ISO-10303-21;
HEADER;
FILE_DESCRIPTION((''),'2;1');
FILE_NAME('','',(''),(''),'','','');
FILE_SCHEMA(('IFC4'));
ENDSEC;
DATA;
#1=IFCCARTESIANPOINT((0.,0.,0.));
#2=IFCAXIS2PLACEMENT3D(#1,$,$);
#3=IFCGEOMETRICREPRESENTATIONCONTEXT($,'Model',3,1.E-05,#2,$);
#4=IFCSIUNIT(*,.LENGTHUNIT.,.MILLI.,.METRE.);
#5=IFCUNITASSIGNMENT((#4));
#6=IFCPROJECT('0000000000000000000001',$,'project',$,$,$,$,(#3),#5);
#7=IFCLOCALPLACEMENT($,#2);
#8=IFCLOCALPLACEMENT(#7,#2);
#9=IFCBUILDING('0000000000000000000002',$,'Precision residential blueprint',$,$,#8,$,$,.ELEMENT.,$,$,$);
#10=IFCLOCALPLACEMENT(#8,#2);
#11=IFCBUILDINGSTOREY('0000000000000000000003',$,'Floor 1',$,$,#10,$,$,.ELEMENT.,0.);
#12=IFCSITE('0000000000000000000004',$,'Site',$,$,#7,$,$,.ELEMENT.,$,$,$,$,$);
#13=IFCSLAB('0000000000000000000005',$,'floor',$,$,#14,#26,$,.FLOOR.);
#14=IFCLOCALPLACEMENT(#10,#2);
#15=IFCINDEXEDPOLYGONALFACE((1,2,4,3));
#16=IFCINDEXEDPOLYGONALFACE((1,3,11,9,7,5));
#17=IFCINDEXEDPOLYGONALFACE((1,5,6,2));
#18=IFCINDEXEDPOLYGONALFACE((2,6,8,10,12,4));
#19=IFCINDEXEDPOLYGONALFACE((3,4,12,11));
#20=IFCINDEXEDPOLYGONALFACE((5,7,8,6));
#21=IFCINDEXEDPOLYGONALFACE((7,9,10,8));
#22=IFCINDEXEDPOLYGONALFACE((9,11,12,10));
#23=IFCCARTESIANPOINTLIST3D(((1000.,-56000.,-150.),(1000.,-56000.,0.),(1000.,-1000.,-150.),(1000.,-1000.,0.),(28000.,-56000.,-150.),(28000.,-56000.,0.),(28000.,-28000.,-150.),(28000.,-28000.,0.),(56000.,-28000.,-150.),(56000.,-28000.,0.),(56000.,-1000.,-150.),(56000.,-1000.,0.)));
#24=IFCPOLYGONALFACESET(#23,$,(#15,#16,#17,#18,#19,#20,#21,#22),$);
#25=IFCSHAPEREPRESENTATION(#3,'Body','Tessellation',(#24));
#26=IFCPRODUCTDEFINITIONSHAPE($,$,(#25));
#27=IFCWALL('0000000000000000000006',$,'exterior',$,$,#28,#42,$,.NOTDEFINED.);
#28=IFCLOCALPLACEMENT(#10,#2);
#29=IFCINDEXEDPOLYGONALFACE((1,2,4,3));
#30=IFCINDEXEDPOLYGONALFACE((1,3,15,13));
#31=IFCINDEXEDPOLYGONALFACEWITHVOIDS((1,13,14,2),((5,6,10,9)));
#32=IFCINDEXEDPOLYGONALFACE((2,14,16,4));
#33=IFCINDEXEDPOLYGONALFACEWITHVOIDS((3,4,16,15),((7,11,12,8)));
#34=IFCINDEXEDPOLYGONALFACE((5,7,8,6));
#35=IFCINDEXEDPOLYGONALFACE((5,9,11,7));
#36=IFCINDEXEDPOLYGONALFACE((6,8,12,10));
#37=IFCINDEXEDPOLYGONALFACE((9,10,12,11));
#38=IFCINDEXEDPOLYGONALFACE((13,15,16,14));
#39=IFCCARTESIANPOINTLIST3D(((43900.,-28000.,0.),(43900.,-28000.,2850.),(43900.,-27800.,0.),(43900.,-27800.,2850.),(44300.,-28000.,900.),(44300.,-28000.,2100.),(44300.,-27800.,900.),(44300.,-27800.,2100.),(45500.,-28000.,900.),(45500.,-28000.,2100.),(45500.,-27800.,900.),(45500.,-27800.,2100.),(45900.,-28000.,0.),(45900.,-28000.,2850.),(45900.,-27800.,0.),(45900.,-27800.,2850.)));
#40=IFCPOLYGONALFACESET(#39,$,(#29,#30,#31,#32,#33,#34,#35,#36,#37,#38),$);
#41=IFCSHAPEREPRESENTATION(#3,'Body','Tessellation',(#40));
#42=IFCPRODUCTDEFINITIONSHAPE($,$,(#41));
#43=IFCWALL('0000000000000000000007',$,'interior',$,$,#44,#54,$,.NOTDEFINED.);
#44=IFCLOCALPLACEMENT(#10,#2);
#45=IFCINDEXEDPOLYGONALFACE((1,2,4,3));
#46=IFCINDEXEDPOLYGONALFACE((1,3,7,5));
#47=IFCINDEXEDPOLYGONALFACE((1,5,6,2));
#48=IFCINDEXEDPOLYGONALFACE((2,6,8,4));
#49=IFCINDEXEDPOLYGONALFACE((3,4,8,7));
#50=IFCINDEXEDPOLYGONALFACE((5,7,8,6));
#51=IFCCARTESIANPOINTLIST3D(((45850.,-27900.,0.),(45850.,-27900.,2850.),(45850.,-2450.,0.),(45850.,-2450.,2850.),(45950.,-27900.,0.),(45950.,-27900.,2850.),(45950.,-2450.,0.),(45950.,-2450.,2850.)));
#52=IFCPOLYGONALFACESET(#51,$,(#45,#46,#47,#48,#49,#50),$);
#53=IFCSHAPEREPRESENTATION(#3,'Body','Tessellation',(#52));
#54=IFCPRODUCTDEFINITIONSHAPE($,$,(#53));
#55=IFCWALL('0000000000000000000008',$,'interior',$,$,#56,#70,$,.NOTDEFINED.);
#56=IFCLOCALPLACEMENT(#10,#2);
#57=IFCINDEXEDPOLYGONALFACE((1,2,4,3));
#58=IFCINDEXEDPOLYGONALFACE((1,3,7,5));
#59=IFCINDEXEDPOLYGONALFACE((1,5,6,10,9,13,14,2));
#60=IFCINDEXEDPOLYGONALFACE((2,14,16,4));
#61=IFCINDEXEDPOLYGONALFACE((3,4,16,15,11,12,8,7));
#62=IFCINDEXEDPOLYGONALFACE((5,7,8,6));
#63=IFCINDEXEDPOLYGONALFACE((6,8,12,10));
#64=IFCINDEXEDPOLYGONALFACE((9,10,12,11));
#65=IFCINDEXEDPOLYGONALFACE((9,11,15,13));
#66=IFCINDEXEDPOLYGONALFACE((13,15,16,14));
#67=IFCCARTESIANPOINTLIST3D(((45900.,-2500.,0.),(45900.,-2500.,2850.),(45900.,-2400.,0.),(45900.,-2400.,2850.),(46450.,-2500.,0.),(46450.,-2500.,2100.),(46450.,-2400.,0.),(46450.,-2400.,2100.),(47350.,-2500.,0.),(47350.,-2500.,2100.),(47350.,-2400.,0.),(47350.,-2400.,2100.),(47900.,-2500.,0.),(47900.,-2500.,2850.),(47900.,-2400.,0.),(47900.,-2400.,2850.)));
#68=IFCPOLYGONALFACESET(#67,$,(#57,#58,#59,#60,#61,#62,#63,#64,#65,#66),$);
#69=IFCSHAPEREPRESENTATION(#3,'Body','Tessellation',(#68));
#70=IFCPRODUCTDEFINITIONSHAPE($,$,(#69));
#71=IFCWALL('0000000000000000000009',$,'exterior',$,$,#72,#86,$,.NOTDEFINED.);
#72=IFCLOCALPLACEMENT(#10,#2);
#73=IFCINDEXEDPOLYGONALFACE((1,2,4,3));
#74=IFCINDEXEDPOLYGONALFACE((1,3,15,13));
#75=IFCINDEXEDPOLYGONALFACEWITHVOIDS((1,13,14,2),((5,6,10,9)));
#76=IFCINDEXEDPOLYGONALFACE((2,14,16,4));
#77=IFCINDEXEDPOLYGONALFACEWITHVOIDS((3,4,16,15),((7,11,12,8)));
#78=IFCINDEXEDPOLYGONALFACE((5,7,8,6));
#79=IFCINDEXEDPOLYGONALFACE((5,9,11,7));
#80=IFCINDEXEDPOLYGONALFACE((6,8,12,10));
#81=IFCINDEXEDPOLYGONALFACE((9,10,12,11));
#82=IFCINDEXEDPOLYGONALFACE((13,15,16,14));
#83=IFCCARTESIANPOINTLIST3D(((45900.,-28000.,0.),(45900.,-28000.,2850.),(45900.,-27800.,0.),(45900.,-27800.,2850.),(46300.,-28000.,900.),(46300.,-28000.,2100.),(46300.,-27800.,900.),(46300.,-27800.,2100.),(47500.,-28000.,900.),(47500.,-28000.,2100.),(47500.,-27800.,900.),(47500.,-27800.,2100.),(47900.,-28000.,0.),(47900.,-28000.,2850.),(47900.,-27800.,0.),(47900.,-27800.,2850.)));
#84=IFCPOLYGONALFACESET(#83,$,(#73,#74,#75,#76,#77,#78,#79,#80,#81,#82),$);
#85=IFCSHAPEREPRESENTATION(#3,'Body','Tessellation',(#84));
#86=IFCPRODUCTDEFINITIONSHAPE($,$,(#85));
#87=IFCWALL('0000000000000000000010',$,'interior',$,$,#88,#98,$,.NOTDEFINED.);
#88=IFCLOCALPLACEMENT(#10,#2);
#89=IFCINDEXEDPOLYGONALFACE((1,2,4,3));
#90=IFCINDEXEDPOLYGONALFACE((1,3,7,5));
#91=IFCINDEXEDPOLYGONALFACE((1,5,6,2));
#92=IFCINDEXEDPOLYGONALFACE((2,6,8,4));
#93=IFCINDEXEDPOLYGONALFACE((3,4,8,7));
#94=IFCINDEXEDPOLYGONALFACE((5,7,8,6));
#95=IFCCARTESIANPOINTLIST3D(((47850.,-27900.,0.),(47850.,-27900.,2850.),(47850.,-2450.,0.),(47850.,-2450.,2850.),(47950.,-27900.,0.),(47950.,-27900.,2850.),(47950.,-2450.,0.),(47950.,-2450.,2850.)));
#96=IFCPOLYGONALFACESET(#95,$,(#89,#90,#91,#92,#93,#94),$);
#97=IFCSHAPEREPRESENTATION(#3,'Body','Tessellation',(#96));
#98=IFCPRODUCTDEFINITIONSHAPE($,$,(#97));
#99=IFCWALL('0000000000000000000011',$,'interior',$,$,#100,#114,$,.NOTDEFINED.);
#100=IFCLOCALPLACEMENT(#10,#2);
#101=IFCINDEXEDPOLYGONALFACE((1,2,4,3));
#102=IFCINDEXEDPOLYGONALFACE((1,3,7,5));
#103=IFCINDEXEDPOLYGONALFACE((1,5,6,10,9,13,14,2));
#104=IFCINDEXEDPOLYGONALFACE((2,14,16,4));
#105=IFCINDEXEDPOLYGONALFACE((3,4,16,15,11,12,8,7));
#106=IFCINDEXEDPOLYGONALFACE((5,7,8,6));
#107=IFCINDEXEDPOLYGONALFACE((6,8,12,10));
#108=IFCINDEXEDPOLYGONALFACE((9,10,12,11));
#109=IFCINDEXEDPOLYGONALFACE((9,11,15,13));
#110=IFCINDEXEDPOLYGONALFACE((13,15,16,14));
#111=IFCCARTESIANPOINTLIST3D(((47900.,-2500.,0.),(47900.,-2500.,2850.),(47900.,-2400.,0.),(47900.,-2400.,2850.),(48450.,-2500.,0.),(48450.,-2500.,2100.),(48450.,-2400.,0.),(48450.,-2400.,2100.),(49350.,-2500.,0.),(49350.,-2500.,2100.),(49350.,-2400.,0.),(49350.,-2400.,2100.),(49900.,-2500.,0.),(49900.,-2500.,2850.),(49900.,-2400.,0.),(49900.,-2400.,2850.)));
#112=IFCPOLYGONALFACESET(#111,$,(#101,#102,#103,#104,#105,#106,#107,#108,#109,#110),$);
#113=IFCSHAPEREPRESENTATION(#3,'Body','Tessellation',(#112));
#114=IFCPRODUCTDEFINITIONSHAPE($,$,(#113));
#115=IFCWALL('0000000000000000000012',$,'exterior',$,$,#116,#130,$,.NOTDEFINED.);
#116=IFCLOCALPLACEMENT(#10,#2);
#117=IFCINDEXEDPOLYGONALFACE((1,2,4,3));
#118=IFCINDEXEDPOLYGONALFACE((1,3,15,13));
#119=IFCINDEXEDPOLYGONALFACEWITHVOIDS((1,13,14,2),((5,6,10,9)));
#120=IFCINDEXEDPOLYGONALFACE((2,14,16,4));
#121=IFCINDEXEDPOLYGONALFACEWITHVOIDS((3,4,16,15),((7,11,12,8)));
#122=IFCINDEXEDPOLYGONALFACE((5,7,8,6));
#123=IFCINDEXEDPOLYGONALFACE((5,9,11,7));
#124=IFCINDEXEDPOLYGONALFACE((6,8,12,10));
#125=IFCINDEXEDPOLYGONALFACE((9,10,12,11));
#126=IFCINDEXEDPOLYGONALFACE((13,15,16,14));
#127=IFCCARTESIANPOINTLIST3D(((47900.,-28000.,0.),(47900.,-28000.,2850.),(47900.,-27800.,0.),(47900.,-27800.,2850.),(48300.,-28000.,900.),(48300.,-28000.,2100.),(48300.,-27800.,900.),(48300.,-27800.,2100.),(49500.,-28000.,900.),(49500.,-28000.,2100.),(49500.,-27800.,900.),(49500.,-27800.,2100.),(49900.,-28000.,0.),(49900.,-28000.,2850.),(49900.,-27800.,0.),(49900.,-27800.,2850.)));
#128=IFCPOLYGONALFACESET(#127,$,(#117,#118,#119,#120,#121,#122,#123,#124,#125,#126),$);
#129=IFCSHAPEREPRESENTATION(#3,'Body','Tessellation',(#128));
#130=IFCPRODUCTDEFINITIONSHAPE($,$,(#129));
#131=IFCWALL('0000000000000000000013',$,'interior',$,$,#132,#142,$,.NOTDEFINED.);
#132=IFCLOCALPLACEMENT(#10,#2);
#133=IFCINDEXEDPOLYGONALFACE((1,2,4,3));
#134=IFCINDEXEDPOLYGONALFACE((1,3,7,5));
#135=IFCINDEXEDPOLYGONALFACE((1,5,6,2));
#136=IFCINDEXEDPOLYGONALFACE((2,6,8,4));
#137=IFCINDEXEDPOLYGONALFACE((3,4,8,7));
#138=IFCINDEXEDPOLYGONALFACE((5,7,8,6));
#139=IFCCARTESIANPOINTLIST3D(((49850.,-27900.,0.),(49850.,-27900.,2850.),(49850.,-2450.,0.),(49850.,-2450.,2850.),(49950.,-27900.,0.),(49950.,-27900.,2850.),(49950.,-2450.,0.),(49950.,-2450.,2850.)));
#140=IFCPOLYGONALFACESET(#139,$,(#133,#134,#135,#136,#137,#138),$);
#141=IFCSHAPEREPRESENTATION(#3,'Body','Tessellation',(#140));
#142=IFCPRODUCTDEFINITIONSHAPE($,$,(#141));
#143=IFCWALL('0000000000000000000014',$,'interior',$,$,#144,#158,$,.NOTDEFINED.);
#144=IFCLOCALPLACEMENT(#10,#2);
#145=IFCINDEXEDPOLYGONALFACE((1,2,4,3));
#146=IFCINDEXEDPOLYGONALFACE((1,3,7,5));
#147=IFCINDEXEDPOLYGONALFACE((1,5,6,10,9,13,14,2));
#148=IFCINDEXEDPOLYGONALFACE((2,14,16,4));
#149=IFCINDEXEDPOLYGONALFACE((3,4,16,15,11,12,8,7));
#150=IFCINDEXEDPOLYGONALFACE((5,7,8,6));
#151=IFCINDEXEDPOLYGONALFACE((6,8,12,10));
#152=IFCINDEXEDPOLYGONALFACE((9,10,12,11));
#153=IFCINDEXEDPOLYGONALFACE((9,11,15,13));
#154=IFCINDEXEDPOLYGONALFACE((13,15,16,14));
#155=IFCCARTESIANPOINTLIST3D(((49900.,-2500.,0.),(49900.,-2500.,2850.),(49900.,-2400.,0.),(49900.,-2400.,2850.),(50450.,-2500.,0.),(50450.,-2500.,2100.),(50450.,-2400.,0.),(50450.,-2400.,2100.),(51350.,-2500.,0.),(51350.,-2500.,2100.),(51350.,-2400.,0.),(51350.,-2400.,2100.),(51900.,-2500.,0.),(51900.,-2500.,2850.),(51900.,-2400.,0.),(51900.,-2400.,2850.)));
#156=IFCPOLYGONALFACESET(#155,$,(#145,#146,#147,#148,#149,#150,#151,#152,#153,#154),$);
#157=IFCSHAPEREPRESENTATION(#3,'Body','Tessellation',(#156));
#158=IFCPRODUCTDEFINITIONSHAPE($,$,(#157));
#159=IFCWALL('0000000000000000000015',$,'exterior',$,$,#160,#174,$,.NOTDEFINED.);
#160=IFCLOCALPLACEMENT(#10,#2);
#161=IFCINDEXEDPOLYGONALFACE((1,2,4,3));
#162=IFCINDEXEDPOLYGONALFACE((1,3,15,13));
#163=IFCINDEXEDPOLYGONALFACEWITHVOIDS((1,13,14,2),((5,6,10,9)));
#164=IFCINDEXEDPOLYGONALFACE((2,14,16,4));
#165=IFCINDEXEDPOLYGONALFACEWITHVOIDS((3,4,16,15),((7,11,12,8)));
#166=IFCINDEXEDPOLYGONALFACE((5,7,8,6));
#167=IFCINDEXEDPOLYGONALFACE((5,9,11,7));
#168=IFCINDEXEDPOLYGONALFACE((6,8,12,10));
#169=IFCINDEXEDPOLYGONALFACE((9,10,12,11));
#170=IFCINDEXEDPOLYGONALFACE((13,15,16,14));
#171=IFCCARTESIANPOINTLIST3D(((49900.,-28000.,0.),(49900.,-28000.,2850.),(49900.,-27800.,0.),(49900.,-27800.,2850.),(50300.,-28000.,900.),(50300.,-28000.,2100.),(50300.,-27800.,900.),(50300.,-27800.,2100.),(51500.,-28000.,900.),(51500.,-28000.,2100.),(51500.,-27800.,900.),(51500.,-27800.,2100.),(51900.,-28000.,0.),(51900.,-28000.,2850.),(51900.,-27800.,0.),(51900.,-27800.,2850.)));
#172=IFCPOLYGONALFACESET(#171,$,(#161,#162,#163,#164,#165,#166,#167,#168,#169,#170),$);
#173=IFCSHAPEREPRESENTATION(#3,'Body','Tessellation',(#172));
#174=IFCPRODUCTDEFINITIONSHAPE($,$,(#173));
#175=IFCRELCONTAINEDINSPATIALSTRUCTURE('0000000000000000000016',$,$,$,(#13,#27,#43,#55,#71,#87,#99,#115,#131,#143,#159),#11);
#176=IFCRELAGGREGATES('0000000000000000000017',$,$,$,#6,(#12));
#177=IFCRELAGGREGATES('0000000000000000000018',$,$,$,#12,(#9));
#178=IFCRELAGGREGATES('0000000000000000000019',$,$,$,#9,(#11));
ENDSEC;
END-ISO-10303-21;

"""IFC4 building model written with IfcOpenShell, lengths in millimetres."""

from ifc_helpers import new_model, si_unit, frame, origin, place, context, project, spatial, polyline, outline, extrude, element, save


model = new_model("IFC4")

# Units and contexts
model_context = context("Model", 3, precision=1e-05, world=origin())
ifc_project = project(units=[si_unit("LENGTHUNIT", "METRE", prefix="MILLI")], contexts=[model_context])

# Site, building, storey
site_placement = place(None, origin())
site = spatial("IfcSite", under=ifc_project, at=site_placement, Name="Site", CompositionType="ELEMENT")
building_placement = place(site_placement, origin())
building = spatial("IfcBuilding", under=site, at=building_placement, Name="Precision residential blueprint", CompositionType="ELEMENT")
storey_placement = place(building_placement, origin())
storey = spatial("IfcBuildingStorey", under=building, at=storey_placement, Name="Floor 1", CompositionType="ELEMENT", Elevation=0.0)

# Slab
slab_placement = place(storey_placement, origin())
element("IfcSlab", 1, at=slab_placement, inside=storey, Name="floor", PredefinedType="FLOOR", context=model_context, shape_type="SweptSolid", body=[
    extrude(outline(polyline([(1000.0, -56000.0), (28000.0, -56000.0), (28000.0, -28000.0), (56000.0, -28000.0), (56000.0, -1000.0), (1000.0, -1000.0), (1000.0, -56000.0)])), frame((0.0, 0.0, -150.0)), (0.0, 0.0, 1.0), 150.0),
])

# Wall, opening
wall_1_placement = place(storey_placement, origin())
wall_1 = element("IfcWall", 2, at=wall_1_placement, inside=storey, Name="exterior", PredefinedType="NOTDEFINED", context=model_context, shape_type="SweptSolid", body=[
    extrude(outline(polyline([(43900.0, -27800.0), (45900.0, -27800.0), (45900.0, -28000.0), (43900.0, -28000.0), (43900.0, -27800.0)])), origin(), (0.0, 0.0, 1.0), 2850.0),
])
opening_1_placement = place(storey_placement, origin())
element("IfcOpeningElement", 3, at=opening_1_placement, cuts=wall_1, PredefinedType="OPENING", context=model_context, shape_type="SweptSolid", body=[
    extrude(outline(polyline([(44300.0, -27800.0), (45500.0, -27800.0), (45500.0, -28000.0), (44300.0, -28000.0), (44300.0, -27800.0)])), frame((0.0, 0.0, 900.0)), (0.0, 0.0, 1.0), 1200.0),
])

# Wall
wall_2_placement = place(storey_placement, origin())
element("IfcWall", 4, at=wall_2_placement, inside=storey, Name="interior", PredefinedType="NOTDEFINED", context=model_context, shape_type="SweptSolid", body=[
    extrude(outline(polyline([(45950.0, -2450.0), (45950.0, -27900.0), (45850.0, -27900.0), (45850.0, -2450.0), (45950.0, -2450.0)])), origin(), (0.0, 0.0, 1.0), 2850.0),
])

# Walls, openings
wall_3_placement = place(storey_placement, origin())
wall_3 = element("IfcWall", 5, at=wall_3_placement, inside=storey, Name="interior", PredefinedType="NOTDEFINED", context=model_context, shape_type="SweptSolid", body=[
    extrude(outline(polyline([(45900.0, -2400.0), (47900.0, -2400.0), (47900.0, -2500.0), (45900.0, -2500.0), (45900.0, -2400.0)])), origin(), (0.0, 0.0, 1.0), 2850.0),
])
opening_2_placement = place(storey_placement, origin())
element("IfcOpeningElement", 6, at=opening_2_placement, cuts=wall_3, PredefinedType="OPENING", context=model_context, shape_type="SweptSolid", body=[
    extrude(outline(polyline([(46450.0, -2400.0), (47350.0, -2400.0), (47350.0, -2500.0), (46450.0, -2500.0), (46450.0, -2400.0)])), origin(), (0.0, 0.0, 1.0), 2100.0),
])
wall_4_placement = place(storey_placement, origin())
wall_4 = element("IfcWall", 7, at=wall_4_placement, inside=storey, Name="exterior", PredefinedType="NOTDEFINED", context=model_context, shape_type="SweptSolid", body=[
    extrude(outline(polyline([(45900.0, -27800.0), (47900.0, -27800.0), (47900.0, -28000.0), (45900.0, -28000.0), (45900.0, -27800.0)])), origin(), (0.0, 0.0, 1.0), 2850.0),
])
opening_3_placement = place(storey_placement, origin())
element("IfcOpeningElement", 8, at=opening_3_placement, cuts=wall_4, PredefinedType="OPENING", context=model_context, shape_type="SweptSolid", body=[
    extrude(outline(polyline([(46300.0, -27800.0), (47500.0, -27800.0), (47500.0, -28000.0), (46300.0, -28000.0), (46300.0, -27800.0)])), frame((0.0, 0.0, 900.0)), (0.0, 0.0, 1.0), 1200.0),
])

# Wall
wall_5_placement = place(storey_placement, origin())
element("IfcWall", 9, at=wall_5_placement, inside=storey, Name="interior", PredefinedType="NOTDEFINED", context=model_context, shape_type="SweptSolid", body=[
    extrude(outline(polyline([(47950.0, -2450.0), (47950.0, -27900.0), (47850.0, -27900.0), (47850.0, -2450.0), (47950.0, -2450.0)])), origin(), (0.0, 0.0, 1.0), 2850.0),
])

# Walls, openings
wall_6_placement = place(storey_placement, origin())
wall_6 = element("IfcWall", 10, at=wall_6_placement, inside=storey, Name="interior", PredefinedType="NOTDEFINED", context=model_context, shape_type="SweptSolid", body=[
    extrude(outline(polyline([(47900.0, -2400.0), (49900.0, -2400.0), (49900.0, -2500.0), (47900.0, -2500.0), (47900.0, -2400.0)])), origin(), (0.0, 0.0, 1.0), 2850.0),
])
opening_4_placement = place(storey_placement, origin())
element("IfcOpeningElement", 11, at=opening_4_placement, cuts=wall_6, PredefinedType="OPENING", context=model_context, shape_type="SweptSolid", body=[
    extrude(outline(polyline([(48450.0, -2400.0), (49350.0, -2400.0), (49350.0, -2500.0), (48450.0, -2500.0), (48450.0, -2400.0)])), origin(), (0.0, 0.0, 1.0), 2100.0),
])
wall_7_placement = place(storey_placement, origin())
wall_7 = element("IfcWall", 12, at=wall_7_placement, inside=storey, Name="exterior", PredefinedType="NOTDEFINED", context=model_context, shape_type="SweptSolid", body=[
    extrude(outline(polyline([(47900.0, -27800.0), (49900.0, -27800.0), (49900.0, -28000.0), (47900.0, -28000.0), (47900.0, -27800.0)])), origin(), (0.0, 0.0, 1.0), 2850.0),
])
opening_5_placement = place(storey_placement, origin())
element("IfcOpeningElement", 13, at=opening_5_placement, cuts=wall_7, PredefinedType="OPENING", context=model_context, shape_type="SweptSolid", body=[
    extrude(outline(polyline([(48300.0, -27800.0), (49500.0, -27800.0), (49500.0, -28000.0), (48300.0, -28000.0), (48300.0, -27800.0)])), frame((0.0, 0.0, 900.0)), (0.0, 0.0, 1.0), 1200.0),
])

# Wall
wall_8_placement = place(storey_placement, origin())
element("IfcWall", 14, at=wall_8_placement, inside=storey, Name="interior", PredefinedType="NOTDEFINED", context=model_context, shape_type="SweptSolid", body=[
    extrude(outline(polyline([(49950.0, -2450.0), (49950.0, -27900.0), (49850.0, -27900.0), (49850.0, -2450.0), (49950.0, -2450.0)])), origin(), (0.0, 0.0, 1.0), 2850.0),
])

# Walls, openings
wall_9_placement = place(storey_placement, origin())
wall_9 = element("IfcWall", 15, at=wall_9_placement, inside=storey, Name="interior", PredefinedType="NOTDEFINED", context=model_context, shape_type="SweptSolid", body=[
    extrude(outline(polyline([(49900.0, -2400.0), (51900.0, -2400.0), (51900.0, -2500.0), (49900.0, -2500.0), (49900.0, -2400.0)])), origin(), (0.0, 0.0, 1.0), 2850.0),
])
opening_6_placement = place(storey_placement, origin())
element("IfcOpeningElement", 16, at=opening_6_placement, cuts=wall_9, PredefinedType="OPENING", context=model_context, shape_type="SweptSolid", body=[
    extrude(outline(polyline([(50450.0, -2400.0), (51350.0, -2400.0), (51350.0, -2500.0), (50450.0, -2500.0), (50450.0, -2400.0)])), origin(), (0.0, 0.0, 1.0), 2100.0),
])
wall_10_placement = place(storey_placement, origin())
wall_10 = element("IfcWall", 17, at=wall_10_placement, inside=storey, Name="exterior", PredefinedType="NOTDEFINED", context=model_context, shape_type="SweptSolid", body=[
    extrude(outline(polyline([(49900.0, -27800.0), (51900.0, -27800.0), (51900.0, -28000.0), (49900.0, -28000.0), (49900.0, -27800.0)])), origin(), (0.0, 0.0, 1.0), 2850.0),
])
opening_7_placement = place(storey_placement, origin())
element("IfcOpeningElement", 18, at=opening_7_placement, cuts=wall_10, PredefinedType="OPENING", context=model_context, shape_type="SweptSolid", body=[
    extrude(outline(polyline([(50300.0, -27800.0), (51500.0, -27800.0), (51500.0, -28000.0), (50300.0, -28000.0), (50300.0, -27800.0)])), frame((0.0, 0.0, 900.0)), (0.0, 0.0, 1.0), 1200.0),
])

save(model, "model.ifc")
